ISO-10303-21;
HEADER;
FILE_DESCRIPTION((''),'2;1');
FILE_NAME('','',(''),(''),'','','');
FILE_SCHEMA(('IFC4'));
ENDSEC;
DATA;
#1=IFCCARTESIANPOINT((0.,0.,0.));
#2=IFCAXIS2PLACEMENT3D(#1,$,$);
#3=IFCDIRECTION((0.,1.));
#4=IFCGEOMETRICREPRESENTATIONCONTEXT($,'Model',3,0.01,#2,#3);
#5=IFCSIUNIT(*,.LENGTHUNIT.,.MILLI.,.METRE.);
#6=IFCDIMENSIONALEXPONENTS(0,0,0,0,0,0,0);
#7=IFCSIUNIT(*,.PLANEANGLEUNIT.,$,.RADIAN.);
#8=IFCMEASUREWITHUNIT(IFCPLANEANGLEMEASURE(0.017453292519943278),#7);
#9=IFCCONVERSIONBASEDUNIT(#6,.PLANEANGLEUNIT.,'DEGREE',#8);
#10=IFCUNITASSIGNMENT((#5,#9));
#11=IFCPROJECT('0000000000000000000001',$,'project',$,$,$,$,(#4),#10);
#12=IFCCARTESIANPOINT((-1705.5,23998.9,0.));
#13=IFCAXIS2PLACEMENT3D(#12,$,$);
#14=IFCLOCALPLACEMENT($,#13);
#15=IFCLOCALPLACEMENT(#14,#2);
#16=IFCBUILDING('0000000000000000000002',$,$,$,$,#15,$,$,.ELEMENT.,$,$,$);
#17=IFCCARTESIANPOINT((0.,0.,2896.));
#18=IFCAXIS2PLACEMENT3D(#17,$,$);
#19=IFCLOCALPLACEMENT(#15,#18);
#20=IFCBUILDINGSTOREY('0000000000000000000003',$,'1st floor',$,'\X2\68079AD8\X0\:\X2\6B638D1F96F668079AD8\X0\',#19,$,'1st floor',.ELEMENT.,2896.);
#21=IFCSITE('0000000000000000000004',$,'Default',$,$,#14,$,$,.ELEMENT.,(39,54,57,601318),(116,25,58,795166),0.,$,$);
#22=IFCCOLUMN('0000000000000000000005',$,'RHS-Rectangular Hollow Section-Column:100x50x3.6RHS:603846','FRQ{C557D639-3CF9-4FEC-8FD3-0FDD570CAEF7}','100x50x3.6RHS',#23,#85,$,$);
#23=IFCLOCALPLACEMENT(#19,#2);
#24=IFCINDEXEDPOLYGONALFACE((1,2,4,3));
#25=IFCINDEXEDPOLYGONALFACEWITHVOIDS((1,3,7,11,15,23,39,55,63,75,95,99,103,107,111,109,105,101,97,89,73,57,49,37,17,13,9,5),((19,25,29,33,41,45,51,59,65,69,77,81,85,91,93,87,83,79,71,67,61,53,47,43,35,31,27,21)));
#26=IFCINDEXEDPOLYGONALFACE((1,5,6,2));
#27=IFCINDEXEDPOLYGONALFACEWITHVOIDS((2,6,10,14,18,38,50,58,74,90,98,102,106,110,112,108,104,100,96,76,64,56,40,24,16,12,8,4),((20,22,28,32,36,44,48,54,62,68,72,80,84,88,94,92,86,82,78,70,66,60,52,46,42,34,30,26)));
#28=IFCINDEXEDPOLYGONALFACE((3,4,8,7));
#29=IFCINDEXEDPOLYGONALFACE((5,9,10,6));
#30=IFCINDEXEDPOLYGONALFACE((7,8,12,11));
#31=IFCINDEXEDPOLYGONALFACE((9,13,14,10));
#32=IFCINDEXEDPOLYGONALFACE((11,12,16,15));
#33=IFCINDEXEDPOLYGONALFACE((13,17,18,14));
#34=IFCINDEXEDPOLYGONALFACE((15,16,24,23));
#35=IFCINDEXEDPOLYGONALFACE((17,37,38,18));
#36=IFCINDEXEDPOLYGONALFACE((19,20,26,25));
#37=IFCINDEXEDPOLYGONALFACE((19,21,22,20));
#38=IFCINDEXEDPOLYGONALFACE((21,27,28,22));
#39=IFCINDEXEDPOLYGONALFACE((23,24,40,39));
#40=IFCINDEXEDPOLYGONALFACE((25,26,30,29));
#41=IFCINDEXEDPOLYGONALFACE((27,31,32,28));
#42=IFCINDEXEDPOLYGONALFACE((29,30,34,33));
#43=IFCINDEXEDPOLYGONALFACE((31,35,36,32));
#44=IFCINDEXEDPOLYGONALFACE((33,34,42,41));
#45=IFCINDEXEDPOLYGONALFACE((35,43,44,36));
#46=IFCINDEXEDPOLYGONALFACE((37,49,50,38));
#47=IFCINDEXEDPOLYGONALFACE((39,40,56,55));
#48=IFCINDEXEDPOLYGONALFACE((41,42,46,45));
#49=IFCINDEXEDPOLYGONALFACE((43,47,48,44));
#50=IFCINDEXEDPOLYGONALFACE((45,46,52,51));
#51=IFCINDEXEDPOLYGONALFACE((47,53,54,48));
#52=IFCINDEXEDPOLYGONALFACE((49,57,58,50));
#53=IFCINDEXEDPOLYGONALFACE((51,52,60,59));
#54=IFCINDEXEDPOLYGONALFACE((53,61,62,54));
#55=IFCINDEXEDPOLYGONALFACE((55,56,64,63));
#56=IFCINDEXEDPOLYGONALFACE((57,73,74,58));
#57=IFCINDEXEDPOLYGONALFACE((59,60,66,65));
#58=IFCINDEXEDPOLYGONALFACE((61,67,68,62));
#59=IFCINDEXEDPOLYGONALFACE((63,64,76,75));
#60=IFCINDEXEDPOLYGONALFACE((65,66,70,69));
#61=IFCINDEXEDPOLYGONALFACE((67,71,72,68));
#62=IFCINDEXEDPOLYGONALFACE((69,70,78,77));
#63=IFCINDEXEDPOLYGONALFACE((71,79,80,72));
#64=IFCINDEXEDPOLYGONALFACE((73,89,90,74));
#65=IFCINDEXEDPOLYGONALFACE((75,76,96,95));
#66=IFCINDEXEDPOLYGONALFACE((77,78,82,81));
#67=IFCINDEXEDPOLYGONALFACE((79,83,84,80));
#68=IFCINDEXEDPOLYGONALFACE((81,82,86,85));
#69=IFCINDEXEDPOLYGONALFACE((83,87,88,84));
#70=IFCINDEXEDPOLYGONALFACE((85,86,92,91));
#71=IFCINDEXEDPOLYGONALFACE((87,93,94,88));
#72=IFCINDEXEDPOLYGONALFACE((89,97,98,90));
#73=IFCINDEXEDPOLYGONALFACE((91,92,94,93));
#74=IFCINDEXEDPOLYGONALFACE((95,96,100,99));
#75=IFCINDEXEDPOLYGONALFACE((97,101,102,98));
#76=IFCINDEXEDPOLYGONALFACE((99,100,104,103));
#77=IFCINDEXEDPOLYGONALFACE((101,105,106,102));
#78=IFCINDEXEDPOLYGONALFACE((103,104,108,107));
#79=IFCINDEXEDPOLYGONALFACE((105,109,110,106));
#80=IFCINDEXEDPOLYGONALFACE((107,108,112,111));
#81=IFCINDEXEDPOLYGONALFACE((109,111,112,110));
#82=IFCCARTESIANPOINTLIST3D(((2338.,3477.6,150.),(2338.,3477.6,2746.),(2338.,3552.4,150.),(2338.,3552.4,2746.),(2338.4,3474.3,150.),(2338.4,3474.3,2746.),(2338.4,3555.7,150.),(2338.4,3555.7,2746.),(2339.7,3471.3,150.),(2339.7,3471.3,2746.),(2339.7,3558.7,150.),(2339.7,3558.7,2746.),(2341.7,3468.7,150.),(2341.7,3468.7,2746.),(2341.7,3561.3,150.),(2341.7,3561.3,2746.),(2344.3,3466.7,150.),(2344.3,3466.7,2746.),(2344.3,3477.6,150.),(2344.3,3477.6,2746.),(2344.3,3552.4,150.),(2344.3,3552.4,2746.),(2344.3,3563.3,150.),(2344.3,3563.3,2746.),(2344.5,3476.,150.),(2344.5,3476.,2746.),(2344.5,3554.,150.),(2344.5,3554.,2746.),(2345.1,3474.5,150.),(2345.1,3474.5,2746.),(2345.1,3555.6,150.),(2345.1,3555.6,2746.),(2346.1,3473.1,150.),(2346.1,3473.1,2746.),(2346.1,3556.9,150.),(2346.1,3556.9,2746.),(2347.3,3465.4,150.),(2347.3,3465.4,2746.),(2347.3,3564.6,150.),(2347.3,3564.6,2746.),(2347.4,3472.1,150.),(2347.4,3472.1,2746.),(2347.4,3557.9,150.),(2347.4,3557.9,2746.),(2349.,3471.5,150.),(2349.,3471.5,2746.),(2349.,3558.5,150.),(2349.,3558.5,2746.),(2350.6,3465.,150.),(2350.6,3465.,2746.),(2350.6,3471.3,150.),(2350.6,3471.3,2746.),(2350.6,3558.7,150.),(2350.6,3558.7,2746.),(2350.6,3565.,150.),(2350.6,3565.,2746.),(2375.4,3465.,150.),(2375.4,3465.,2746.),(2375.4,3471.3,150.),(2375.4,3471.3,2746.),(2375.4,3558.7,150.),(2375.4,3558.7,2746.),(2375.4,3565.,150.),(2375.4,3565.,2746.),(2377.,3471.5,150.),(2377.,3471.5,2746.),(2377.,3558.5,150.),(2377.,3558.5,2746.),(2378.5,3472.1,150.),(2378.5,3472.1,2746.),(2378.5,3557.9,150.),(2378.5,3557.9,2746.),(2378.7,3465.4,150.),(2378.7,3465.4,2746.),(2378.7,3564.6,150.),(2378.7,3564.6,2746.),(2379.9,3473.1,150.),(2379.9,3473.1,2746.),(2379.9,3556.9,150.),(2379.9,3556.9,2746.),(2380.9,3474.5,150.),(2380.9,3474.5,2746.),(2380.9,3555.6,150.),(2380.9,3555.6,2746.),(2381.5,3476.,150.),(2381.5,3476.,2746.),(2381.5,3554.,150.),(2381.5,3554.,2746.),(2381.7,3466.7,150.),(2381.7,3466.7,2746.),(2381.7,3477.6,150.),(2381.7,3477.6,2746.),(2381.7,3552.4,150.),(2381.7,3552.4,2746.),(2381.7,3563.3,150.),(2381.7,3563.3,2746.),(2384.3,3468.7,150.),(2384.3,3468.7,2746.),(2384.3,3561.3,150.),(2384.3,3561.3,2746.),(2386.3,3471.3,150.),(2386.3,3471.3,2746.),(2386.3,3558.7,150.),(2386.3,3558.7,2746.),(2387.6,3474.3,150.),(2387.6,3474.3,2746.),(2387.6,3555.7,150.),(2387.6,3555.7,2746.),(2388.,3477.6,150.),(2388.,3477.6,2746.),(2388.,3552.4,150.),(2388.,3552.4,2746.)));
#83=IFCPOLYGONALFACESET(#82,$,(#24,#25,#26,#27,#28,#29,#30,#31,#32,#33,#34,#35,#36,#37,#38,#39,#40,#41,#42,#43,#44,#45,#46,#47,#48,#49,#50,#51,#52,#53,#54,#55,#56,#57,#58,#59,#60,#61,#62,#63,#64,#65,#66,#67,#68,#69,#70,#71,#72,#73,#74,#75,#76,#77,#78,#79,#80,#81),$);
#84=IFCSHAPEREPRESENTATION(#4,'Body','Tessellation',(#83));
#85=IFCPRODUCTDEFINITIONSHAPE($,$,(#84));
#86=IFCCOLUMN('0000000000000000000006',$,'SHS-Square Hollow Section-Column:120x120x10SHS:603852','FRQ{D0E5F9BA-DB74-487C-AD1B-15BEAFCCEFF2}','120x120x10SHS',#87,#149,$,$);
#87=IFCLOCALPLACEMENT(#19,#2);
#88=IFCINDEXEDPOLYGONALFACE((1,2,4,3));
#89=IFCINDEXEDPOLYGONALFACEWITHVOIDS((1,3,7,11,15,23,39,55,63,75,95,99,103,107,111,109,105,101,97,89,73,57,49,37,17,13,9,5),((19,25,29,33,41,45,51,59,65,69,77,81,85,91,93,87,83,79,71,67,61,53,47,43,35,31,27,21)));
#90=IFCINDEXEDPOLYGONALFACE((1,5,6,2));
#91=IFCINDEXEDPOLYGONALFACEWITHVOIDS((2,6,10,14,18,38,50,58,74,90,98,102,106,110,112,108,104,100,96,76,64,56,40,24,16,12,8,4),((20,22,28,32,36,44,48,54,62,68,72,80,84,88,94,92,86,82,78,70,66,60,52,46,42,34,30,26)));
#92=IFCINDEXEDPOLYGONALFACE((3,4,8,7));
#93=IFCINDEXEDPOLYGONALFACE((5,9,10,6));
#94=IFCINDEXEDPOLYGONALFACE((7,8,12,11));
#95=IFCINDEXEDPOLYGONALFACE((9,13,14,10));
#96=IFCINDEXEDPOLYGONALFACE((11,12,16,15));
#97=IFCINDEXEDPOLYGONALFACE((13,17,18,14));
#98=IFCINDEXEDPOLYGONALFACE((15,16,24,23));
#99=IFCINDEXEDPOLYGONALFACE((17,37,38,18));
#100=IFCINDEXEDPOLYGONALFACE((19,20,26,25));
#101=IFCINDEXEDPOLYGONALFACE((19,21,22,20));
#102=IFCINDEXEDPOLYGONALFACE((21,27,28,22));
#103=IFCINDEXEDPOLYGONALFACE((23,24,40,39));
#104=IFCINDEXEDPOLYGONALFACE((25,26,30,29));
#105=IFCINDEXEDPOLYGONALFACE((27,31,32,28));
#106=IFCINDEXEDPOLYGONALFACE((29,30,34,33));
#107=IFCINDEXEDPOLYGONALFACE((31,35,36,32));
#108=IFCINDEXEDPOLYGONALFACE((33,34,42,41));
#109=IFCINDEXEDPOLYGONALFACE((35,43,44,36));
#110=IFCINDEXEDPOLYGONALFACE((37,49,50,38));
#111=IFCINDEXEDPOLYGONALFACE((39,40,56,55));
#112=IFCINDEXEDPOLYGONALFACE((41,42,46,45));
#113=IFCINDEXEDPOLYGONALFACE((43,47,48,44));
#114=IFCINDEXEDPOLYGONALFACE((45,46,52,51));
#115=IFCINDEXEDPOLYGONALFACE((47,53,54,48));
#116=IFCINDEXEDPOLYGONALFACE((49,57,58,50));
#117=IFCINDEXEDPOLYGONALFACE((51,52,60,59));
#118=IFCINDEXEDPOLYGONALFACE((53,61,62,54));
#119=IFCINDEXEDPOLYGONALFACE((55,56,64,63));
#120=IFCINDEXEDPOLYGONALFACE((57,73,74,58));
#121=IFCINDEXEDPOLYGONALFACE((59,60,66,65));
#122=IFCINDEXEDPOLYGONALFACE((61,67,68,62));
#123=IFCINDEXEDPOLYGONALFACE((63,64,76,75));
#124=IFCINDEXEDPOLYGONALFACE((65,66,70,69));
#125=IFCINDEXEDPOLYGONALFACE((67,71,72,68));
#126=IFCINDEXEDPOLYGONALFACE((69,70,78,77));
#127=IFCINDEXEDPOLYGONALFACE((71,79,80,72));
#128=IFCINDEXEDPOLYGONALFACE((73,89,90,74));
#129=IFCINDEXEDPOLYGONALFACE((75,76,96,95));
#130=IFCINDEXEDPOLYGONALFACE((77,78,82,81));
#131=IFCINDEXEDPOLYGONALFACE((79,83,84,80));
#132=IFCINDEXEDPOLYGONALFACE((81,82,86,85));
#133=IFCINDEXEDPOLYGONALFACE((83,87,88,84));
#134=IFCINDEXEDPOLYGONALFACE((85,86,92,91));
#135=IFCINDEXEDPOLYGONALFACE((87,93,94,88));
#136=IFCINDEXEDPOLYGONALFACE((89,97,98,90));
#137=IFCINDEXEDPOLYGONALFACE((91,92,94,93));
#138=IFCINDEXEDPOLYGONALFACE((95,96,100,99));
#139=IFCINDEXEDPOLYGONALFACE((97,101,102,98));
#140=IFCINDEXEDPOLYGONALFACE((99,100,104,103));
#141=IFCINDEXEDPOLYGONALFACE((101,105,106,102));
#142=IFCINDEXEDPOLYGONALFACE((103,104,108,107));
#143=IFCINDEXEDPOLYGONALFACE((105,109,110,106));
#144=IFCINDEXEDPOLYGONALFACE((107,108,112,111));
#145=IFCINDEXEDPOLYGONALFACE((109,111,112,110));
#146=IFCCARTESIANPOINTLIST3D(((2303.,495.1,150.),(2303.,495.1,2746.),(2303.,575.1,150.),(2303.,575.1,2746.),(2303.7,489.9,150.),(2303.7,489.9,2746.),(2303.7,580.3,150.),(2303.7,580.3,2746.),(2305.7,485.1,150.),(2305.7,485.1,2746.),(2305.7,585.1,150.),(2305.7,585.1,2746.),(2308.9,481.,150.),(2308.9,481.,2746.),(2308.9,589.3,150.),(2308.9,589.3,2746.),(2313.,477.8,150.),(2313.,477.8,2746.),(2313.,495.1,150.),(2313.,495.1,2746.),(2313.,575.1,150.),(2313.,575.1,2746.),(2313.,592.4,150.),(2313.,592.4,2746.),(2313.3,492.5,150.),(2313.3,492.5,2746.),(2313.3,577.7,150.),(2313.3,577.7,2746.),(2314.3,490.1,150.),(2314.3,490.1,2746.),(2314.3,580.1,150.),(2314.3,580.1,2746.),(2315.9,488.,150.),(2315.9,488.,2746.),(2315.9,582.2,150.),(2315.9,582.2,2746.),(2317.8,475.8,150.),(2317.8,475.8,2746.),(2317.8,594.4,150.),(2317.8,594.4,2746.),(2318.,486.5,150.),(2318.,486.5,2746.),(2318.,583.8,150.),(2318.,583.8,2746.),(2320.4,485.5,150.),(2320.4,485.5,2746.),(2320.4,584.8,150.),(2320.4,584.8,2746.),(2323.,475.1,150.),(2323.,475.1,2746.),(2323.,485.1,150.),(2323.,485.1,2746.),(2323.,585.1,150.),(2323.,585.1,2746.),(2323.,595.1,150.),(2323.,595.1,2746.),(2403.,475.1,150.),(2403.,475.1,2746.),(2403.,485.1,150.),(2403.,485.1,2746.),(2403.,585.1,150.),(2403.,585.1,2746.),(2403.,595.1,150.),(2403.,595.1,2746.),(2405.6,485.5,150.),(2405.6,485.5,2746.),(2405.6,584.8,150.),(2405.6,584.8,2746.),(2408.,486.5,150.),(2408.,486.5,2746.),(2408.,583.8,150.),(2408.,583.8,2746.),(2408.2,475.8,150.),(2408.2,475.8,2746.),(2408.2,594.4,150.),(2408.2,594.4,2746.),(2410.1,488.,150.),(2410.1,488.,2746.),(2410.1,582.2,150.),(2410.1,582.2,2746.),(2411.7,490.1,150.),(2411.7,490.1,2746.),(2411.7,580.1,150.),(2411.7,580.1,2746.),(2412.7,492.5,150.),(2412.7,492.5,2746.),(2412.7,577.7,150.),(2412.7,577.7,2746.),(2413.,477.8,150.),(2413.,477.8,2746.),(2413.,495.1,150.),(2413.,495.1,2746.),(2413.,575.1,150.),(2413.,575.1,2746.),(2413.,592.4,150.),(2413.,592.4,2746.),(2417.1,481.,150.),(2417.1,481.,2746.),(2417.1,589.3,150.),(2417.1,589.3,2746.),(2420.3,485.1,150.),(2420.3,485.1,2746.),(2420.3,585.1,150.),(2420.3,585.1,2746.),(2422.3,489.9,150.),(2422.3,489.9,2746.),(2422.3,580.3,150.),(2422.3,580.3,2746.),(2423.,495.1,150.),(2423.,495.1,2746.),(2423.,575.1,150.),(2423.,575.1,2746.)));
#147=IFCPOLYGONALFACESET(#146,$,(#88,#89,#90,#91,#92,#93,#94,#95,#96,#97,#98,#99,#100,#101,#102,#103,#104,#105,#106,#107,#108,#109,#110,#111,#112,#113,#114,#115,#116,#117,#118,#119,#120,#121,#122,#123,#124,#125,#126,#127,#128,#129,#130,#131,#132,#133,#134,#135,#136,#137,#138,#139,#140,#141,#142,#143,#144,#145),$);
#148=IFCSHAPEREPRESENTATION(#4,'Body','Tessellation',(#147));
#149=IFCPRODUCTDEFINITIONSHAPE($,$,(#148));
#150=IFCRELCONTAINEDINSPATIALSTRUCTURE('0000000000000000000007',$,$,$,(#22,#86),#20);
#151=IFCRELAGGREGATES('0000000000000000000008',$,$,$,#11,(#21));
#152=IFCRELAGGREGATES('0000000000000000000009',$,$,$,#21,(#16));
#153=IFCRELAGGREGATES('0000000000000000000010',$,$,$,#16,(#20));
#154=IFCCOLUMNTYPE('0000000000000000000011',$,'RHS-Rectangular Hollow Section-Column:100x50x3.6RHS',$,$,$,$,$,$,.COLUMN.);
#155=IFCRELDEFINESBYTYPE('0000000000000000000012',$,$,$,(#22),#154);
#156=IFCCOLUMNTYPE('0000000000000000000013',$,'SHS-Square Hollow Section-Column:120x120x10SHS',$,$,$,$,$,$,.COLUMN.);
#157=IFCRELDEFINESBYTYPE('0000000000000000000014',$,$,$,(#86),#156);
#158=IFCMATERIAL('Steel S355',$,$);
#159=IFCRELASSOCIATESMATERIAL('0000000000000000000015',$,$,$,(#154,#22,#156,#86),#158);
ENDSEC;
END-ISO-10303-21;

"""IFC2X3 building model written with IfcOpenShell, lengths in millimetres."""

from ifc_helpers import new_model, entity, si_unit, converted_unit, direction, frame, origin, origin_2d, place, context, project, spatial, hollow_rectangle, extrude, clip, halfspace, material, type_object, element, save


model = new_model("IFC2X3")

# Units and contexts
model_context = context("Model", 3, precision=0.01, world=origin(), true_north=direction((0.0, 1.0)))
ifc_project = project(units=[si_unit("LENGTHUNIT", "METRE", prefix="MILLI"), converted_unit("PLANEANGLEUNIT", "DEGREE", entity("IfcPlaneAngleMeasure", 0.017453292519943278), si_unit("PLANEANGLEUNIT", "RADIAN"), dimensions=[0, 0, 0, 0, 0, 0, 0])], contexts=[model_context])

# Site, building, storey
site_placement = place(None, frame((-1705.5, 23998.9, 0.0)))
site = spatial("IfcSite", under=ifc_project, at=site_placement, Name="Default", CompositionType="ELEMENT", RefLatitude=(39, 54, 57, 601318), RefLongitude=(116, 25, 58, 795166), RefElevation=0.0)
building_placement = place(site_placement, origin())
building = spatial("IfcBuilding", under=site, at=building_placement, CompositionType="ELEMENT")
storey_placement = place(building_placement, frame((0.0, 0.0, 2896.0)))
storey = spatial("IfcBuildingStorey", under=building, at=storey_placement, Name="1st floor", ObjectType="标高:正负零标高", LongName="1st floor", CompositionType="ELEMENT", Elevation=2896.0)

# Shared definitions
ifc_material_1 = material(Name="Steel S355")
column_type_1 = type_object("IfcColumnType", Name="RHS-Rectangular Hollow Section-Column:100x50x3.6RHS", PredefinedType="COLUMN", material=ifc_material_1)

# Column
column_1_placement = place(storey_placement, frame((2363.0, 3515.0, 2746.0), z_axis=(0.0, 0.0, 1.0), x_axis=(-1.0, 0.0, 0.0)))
element("IfcColumn", 1, at=column_1_placement, inside=storey, type_object=column_type_1, material=ifc_material_1, Name="RHS-Rectangular Hollow Section-Column:100x50x3.6RHS:603846", Description="FRQ{C557D639-3CF9-4FEC-8FD3-0FDD570CAEF7}", ObjectType="100x50x3.6RHS", context=model_context, shape_type="Clipping", body=[
    clip(extrude(hollow_rectangle(XDim=50.0, YDim=100.0, WallThickness=6.3, InnerFilletRadius=6.3, OuterFilletRadius=12.6, at=origin_2d()), origin(), (0.0, 0.0, -1.0), 2651.9), halfspace(frame((2363.0, 3515.0, -2596.0), z_axis=(0.0, 0.0, 1.0), x_axis=(-1.0, 0.0, 0.0)), True)),
])

# Shared definitions
column_type_2 = type_object("IfcColumnType", Name="SHS-Square Hollow Section-Column:120x120x10SHS", PredefinedType="COLUMN", material=ifc_material_1)

# Column
column_2_placement = place(storey_placement, frame((2363.0, 535.1, 2830.9), z_axis=(0.0, 0.0, 1.0), x_axis=(0.0, 1.0, 0.0)))
element("IfcColumn", 2, at=column_2_placement, inside=storey, type_object=column_type_2, material=ifc_material_1, Name="SHS-Square Hollow Section-Column:120x120x10SHS:603852", Description="FRQ{D0E5F9BA-DB74-487C-AD1B-15BEAFCCEFF2}", ObjectType="120x120x10SHS", context=model_context, shape_type="Clipping", body=[
    clip(clip(extrude(hollow_rectangle(XDim=120.0, YDim=120.0, WallThickness=10.0, InnerFilletRadius=10.0, OuterFilletRadius=20.0, at=origin_2d()), origin(), (0.0, 0.0, -1.0), 2765.7), halfspace(frame((-535.1, 2363.0, -2680.9), z_axis=(0.0, 0.0, 1.0), x_axis=(0.0, -1.0, 0.0)), True)), halfspace(frame((-535.1, 2363.0, -84.9), z_axis=(0.0, 0.0, -1.0), x_axis=(0.0, 1.0, 0.0)), True)),
])

save(model, "model.ifc")
